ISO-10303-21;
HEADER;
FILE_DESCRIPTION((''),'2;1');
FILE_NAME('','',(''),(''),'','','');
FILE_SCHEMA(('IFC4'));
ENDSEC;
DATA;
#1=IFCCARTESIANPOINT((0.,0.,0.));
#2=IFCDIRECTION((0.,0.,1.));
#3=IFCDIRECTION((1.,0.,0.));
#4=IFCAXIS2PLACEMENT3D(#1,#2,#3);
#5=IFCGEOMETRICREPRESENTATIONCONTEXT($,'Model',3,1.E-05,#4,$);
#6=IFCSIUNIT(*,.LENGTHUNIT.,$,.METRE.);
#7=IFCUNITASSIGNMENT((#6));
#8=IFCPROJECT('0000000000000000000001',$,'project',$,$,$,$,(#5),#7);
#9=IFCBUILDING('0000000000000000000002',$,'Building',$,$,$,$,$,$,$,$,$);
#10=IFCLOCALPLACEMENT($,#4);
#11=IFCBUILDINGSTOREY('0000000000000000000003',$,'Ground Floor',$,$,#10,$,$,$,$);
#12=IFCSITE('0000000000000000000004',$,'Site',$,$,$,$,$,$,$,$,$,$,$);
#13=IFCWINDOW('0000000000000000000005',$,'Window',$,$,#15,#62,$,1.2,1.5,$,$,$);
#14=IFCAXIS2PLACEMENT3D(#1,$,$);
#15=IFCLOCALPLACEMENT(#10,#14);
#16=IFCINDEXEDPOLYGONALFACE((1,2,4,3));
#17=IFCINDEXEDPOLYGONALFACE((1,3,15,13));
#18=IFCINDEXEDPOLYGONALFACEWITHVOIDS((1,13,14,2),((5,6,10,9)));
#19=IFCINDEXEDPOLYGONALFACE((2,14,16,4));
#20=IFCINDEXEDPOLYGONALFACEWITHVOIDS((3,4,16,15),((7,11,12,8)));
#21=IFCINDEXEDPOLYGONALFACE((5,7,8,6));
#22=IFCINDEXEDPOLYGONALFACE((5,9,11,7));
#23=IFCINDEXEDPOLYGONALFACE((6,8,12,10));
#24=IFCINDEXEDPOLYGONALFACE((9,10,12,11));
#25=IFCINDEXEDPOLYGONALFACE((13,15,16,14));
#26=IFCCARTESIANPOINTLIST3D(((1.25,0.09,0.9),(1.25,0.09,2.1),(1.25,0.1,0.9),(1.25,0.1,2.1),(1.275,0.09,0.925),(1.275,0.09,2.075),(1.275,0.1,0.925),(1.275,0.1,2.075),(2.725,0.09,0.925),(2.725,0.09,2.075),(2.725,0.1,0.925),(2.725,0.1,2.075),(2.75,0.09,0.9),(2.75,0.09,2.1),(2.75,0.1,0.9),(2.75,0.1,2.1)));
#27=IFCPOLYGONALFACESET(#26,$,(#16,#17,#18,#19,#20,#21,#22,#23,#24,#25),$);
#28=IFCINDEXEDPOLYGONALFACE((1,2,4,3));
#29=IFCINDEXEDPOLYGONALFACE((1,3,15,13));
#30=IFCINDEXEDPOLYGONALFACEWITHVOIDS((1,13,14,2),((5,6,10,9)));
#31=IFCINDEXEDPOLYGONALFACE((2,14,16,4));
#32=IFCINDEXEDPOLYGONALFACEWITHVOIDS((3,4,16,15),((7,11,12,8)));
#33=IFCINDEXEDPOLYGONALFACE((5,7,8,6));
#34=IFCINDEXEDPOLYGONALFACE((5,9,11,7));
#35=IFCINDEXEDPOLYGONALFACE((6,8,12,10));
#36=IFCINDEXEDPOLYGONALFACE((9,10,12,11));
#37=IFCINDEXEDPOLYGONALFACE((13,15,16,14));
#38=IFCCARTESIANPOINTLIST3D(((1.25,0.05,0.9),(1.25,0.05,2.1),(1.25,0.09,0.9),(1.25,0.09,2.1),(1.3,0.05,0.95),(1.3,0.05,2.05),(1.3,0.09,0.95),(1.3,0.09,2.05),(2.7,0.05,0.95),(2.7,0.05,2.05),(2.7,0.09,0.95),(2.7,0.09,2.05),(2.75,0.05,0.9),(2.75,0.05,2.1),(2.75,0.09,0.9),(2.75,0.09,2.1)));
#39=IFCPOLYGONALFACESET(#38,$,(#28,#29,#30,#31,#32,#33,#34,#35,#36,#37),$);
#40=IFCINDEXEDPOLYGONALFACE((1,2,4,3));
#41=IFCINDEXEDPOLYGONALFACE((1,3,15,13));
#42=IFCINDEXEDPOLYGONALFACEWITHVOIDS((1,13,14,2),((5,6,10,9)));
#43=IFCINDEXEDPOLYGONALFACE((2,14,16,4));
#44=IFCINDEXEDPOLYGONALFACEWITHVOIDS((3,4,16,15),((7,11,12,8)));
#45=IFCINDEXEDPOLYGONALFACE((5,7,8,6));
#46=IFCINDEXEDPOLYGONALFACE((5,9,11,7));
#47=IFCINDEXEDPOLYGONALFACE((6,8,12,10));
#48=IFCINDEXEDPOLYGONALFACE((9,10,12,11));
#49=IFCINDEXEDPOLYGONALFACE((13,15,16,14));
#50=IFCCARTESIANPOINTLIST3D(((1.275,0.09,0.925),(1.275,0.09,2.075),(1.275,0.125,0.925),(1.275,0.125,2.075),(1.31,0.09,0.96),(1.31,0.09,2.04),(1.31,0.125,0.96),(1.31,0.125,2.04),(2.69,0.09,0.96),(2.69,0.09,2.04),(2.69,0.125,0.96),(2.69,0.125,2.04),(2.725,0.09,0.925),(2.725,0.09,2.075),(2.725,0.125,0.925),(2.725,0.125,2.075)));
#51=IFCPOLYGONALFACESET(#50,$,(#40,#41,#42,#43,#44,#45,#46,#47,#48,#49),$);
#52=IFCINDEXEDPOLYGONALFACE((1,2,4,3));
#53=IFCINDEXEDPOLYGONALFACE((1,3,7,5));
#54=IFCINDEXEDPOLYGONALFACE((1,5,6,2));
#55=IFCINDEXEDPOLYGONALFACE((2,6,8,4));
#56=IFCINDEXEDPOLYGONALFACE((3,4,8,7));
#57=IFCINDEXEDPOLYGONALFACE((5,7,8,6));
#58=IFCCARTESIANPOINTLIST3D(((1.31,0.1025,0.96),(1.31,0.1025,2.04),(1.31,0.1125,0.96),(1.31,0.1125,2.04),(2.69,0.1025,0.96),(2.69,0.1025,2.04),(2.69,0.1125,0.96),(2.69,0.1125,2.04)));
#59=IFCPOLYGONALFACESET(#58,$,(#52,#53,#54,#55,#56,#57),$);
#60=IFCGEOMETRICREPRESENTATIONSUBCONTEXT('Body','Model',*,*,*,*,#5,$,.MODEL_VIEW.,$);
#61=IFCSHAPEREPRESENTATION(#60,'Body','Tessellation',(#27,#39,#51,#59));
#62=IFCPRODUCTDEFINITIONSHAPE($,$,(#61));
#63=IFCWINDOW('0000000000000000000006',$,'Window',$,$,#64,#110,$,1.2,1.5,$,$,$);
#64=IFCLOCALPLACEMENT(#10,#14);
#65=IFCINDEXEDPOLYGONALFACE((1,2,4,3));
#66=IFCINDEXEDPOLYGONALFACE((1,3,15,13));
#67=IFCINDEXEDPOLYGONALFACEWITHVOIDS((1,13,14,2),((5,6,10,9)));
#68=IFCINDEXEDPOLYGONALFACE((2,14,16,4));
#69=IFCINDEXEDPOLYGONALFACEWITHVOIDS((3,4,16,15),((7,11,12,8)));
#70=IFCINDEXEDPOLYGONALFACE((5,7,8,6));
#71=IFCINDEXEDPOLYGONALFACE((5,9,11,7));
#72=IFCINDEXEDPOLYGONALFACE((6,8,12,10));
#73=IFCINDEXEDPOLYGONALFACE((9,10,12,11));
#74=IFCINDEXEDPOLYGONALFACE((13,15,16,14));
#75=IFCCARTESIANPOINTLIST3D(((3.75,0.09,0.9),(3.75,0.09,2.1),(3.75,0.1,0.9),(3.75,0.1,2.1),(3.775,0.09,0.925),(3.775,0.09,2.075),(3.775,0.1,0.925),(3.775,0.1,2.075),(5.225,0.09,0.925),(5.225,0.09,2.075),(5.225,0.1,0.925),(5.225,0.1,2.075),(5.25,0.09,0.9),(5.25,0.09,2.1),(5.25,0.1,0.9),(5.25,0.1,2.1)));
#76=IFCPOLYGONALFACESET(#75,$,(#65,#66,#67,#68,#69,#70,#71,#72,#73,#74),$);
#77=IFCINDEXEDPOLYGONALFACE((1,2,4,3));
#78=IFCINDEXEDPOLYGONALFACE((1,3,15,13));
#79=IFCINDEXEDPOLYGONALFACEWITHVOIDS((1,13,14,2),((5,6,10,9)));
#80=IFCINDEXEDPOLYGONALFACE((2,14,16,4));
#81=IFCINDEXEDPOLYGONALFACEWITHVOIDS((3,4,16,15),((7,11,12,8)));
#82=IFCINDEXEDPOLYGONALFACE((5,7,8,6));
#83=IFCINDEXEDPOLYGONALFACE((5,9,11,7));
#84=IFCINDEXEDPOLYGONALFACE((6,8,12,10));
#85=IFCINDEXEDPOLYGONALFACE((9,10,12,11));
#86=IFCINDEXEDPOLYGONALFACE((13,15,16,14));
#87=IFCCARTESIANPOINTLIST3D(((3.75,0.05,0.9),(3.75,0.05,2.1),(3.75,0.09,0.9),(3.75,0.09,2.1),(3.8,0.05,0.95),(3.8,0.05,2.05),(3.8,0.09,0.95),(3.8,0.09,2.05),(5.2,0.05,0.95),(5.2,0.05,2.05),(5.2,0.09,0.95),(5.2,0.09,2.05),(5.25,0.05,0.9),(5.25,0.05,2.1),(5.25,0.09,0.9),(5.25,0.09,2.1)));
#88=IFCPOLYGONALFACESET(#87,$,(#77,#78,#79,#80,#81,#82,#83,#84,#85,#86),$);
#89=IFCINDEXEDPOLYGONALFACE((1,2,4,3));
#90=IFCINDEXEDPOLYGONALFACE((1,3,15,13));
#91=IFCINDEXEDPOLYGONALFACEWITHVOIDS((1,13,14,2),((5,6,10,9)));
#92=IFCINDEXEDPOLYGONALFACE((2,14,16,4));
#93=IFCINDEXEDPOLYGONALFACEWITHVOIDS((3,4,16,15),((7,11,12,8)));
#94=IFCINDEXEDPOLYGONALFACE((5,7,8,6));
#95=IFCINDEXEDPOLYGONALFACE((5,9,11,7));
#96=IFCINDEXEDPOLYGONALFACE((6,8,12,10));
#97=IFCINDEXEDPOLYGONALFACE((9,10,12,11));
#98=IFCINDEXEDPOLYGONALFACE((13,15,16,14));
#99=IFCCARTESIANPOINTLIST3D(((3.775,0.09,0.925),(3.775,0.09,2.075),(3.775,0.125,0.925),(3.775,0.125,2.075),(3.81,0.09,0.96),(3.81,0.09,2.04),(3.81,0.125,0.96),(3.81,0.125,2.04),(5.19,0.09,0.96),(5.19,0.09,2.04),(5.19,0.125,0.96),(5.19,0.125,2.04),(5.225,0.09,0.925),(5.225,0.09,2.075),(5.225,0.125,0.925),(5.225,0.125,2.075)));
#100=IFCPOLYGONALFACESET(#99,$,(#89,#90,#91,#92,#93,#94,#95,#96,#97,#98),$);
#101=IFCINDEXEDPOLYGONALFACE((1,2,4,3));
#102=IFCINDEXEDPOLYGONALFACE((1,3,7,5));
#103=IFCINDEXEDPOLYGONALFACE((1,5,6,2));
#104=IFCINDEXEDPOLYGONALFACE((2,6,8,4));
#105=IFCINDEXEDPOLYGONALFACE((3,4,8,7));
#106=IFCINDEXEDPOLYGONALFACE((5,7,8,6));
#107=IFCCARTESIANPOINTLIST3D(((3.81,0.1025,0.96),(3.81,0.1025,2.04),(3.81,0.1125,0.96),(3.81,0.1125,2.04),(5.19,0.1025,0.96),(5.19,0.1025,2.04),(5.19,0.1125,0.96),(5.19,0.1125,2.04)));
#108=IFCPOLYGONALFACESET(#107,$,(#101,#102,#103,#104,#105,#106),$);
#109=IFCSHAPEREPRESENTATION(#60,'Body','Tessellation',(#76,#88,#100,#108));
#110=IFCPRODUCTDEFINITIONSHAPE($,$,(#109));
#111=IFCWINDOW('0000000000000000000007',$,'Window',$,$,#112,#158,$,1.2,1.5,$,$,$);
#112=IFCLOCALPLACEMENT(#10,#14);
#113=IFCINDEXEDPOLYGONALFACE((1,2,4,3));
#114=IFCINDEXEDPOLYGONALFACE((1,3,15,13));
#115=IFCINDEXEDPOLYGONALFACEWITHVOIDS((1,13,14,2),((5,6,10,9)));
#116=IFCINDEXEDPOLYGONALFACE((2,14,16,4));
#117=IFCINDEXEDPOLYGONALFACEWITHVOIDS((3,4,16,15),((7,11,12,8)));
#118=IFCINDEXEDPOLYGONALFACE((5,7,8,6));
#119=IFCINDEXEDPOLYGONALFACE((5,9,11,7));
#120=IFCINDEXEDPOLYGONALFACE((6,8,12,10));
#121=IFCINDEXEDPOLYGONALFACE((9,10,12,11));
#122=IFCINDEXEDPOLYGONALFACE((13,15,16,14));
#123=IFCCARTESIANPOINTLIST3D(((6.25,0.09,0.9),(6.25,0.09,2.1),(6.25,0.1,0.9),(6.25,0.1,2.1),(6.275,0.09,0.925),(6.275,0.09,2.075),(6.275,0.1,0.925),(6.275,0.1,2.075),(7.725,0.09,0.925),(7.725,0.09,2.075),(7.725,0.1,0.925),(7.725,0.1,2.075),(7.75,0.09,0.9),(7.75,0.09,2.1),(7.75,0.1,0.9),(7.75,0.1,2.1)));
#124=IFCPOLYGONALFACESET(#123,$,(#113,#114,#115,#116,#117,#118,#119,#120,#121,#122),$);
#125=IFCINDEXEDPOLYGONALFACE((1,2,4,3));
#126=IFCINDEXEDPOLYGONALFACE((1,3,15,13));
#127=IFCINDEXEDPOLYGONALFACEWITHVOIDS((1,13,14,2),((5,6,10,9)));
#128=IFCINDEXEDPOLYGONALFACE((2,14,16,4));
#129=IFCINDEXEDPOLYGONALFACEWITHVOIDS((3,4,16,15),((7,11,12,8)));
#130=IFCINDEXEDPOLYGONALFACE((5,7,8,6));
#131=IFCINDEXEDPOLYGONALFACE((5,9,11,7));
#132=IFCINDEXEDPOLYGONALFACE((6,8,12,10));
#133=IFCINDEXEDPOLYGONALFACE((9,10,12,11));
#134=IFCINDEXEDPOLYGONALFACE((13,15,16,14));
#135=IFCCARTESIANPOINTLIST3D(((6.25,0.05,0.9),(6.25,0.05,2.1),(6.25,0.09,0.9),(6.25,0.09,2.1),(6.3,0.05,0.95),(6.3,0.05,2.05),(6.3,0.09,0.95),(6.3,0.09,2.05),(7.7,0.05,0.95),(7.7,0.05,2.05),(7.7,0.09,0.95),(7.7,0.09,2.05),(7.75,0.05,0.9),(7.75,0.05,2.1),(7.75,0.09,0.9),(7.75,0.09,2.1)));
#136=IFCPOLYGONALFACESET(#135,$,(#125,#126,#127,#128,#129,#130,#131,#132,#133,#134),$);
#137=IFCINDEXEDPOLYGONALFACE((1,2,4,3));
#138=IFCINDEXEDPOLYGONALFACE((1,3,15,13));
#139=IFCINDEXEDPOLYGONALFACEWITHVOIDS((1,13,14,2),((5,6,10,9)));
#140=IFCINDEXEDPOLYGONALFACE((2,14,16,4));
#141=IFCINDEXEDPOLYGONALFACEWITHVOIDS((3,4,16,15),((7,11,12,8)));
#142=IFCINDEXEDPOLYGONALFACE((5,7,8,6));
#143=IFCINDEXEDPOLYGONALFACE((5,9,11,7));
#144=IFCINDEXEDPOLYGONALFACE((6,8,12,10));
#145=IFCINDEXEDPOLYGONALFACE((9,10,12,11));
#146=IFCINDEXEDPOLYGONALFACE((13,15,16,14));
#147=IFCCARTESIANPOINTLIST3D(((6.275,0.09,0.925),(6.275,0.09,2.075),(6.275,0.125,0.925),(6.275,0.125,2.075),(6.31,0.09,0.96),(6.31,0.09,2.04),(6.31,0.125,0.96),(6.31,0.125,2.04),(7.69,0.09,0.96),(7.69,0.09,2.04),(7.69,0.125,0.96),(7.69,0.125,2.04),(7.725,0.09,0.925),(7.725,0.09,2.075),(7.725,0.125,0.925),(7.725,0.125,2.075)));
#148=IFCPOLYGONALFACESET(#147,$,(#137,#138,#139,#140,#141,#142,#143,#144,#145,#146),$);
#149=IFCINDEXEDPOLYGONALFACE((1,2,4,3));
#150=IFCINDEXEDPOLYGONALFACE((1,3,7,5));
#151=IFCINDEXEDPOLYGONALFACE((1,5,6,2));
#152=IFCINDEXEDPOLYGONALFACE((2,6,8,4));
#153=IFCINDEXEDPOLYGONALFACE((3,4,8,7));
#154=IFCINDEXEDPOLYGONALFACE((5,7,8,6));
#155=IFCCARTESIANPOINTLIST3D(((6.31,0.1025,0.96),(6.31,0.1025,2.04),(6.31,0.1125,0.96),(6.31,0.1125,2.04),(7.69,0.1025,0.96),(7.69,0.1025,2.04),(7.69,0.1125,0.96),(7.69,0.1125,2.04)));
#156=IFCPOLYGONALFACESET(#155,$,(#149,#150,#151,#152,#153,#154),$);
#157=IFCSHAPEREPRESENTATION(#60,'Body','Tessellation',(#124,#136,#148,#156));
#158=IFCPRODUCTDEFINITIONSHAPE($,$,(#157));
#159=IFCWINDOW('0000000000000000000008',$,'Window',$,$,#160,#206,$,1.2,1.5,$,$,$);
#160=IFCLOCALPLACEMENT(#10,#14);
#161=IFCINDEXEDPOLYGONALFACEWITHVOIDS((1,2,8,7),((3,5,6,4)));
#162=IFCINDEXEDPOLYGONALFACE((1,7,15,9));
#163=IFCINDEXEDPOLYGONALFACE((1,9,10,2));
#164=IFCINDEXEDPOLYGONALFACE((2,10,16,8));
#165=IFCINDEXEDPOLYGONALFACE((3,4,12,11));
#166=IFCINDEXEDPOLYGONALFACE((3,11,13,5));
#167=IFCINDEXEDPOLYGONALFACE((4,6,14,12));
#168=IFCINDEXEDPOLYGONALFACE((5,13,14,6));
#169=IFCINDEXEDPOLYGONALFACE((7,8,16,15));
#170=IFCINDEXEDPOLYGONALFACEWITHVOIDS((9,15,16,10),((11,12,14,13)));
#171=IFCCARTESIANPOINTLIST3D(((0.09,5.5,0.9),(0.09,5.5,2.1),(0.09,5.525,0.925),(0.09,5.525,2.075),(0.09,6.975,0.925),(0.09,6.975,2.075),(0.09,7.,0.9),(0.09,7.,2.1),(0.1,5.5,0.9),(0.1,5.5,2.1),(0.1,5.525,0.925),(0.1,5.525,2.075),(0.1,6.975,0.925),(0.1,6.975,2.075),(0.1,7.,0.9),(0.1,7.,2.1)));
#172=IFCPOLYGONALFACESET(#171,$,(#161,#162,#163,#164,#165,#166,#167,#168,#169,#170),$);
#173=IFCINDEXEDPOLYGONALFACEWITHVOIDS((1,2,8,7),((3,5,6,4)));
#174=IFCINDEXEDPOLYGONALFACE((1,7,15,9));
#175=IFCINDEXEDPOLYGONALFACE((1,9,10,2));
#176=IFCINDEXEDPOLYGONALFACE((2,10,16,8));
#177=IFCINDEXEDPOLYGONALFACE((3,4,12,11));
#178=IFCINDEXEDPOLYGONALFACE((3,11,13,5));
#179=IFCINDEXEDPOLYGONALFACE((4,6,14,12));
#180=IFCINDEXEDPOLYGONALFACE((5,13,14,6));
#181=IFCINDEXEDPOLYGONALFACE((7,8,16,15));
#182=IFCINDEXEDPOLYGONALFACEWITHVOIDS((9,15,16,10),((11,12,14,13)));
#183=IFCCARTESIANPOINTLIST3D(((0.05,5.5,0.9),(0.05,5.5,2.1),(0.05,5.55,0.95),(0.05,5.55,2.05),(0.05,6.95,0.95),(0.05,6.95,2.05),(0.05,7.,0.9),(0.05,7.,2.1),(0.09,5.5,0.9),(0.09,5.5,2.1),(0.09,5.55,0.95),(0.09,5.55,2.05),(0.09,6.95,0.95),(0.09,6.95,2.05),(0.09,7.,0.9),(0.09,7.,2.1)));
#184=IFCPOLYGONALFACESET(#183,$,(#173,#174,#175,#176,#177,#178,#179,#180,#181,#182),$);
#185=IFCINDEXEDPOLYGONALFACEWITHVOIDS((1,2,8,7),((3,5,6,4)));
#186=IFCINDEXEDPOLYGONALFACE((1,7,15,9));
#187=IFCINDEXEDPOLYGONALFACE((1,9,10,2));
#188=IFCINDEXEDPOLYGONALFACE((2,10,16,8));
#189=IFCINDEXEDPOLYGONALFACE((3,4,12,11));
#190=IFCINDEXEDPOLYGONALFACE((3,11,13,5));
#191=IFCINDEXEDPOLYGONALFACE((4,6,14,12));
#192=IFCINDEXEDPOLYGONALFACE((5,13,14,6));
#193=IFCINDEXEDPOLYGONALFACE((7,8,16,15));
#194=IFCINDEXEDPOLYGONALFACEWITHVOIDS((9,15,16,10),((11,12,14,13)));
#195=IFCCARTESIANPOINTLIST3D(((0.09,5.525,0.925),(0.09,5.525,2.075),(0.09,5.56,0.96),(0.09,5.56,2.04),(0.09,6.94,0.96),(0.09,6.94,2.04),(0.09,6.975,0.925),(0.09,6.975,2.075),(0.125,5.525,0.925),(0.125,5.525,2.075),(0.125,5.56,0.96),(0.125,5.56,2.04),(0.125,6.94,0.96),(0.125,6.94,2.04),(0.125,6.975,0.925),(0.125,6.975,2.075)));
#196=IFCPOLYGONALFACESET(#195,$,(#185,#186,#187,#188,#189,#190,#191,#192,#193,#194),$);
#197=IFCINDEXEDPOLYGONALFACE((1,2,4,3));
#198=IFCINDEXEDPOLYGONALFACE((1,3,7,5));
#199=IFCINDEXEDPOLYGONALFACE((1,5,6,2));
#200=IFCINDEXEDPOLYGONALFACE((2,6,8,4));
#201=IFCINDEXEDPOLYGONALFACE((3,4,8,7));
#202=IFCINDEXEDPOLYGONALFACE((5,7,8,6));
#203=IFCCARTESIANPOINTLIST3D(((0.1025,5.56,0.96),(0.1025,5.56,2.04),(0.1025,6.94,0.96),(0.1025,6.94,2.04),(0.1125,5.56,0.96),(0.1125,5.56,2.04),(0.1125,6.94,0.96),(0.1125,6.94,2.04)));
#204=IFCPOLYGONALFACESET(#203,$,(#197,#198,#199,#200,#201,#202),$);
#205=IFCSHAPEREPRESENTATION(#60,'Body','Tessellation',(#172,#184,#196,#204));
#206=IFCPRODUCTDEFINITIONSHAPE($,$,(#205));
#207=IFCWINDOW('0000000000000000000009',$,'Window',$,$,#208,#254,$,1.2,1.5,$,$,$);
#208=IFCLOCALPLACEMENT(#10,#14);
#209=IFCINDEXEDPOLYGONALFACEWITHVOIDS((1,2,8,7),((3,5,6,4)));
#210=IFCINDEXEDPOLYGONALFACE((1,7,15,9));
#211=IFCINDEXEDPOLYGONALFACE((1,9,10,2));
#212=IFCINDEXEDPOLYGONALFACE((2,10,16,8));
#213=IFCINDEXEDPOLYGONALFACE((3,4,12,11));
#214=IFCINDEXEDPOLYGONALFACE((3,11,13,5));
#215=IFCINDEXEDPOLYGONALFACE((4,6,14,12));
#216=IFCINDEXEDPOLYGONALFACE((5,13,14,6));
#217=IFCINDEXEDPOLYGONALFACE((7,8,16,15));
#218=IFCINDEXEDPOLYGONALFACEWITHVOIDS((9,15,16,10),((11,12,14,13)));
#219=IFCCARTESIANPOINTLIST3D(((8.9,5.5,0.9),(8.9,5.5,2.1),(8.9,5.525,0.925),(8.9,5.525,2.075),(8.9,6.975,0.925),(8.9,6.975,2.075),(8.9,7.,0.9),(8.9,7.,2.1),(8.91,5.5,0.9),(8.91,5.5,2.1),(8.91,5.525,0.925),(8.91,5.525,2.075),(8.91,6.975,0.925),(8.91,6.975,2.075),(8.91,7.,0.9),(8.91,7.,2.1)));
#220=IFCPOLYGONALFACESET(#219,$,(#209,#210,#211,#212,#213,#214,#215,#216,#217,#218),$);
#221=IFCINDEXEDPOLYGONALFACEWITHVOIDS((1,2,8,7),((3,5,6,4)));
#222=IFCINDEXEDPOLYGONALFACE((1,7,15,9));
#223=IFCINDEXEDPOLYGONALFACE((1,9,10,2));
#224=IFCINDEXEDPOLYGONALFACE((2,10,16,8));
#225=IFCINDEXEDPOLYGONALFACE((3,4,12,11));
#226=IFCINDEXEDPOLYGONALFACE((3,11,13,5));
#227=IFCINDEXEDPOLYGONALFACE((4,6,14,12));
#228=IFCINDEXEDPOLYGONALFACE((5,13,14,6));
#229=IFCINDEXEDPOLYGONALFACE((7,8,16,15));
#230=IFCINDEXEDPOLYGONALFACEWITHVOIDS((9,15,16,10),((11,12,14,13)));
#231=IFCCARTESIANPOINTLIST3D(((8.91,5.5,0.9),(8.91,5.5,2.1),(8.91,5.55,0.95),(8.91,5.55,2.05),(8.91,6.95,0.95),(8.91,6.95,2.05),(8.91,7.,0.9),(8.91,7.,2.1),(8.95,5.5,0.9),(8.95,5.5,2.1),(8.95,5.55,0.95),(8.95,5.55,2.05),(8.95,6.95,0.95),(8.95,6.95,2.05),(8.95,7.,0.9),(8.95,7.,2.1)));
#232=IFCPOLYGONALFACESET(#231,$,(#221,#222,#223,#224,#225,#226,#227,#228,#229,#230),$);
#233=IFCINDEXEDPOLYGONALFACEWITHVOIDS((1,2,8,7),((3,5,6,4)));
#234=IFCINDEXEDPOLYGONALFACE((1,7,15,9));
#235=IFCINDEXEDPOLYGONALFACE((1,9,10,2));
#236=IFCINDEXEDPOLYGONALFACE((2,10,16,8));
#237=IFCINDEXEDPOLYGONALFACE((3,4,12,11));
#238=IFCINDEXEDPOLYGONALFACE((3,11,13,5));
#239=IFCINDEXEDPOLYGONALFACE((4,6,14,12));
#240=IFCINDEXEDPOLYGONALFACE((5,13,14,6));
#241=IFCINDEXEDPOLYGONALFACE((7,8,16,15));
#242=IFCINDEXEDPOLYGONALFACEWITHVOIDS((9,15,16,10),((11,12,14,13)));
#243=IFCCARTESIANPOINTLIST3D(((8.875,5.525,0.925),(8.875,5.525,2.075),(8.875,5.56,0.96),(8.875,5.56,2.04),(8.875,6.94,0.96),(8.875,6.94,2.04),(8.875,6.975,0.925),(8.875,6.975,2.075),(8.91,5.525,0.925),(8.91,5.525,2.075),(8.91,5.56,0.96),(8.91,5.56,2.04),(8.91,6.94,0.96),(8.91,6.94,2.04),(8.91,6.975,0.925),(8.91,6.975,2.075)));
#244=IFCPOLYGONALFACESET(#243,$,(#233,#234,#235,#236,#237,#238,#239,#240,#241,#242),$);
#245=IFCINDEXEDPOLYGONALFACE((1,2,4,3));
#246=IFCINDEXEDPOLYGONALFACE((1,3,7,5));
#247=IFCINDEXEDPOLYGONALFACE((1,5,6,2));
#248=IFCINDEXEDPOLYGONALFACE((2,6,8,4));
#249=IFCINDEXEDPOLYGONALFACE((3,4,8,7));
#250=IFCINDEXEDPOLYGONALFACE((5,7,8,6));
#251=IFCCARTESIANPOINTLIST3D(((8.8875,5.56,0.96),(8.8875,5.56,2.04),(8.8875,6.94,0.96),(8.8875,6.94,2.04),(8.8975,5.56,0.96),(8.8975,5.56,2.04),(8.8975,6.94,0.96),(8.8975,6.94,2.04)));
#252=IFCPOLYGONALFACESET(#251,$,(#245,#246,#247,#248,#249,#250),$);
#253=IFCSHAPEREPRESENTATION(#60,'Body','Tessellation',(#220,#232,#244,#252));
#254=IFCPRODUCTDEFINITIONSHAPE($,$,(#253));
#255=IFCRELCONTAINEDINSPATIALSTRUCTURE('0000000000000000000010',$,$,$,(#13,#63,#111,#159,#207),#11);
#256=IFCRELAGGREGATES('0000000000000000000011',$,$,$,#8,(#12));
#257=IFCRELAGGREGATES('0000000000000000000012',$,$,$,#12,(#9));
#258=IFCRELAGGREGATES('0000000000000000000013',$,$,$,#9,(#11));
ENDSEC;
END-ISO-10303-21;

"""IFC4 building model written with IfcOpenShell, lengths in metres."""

from ifc_helpers import new_model, si_unit, frame, origin_with_axes, place, context, subcontext, project, spatial, line, indexed_curve, outline, extrude, element, save


model = new_model("IFC4")

# Units and contexts
model_context = context("Model", 3, precision=1e-05, world=origin_with_axes())
body_context = subcontext(model_context, "Body", "Model", "MODEL_VIEW")
ifc_project = project(units=[si_unit("LENGTHUNIT", "METRE")], contexts=[model_context])

# Site, building, storey
site = spatial("IfcSite", under=ifc_project, Name="Site")
building = spatial("IfcBuilding", under=site, Name="Building")
storey_placement = place(None, origin_with_axes())
storey = spatial("IfcBuildingStorey", under=building, at=storey_placement, Name="Ground Floor")

# Windows
for number, where, z_axis, x_axis, name in (
    (1, (1.25, 0.0, 0.9), (0.0, 0.0, 1.0), (1.0, 0.0, 0.0), "Window"),
    (2, (3.75, 0.0, 0.9), (0.0, 0.0, 1.0), (1.0, 0.0, 0.0), "Window"),
    (3, (6.25, 0.0, 0.9), (0.0, 0.0, 1.0), (1.0, 0.0, 0.0), "Window"),
    (4, (0.0, 7.0, 0.9), (0.0, 0.0, 1.0), (0.0, -1.0, 0.0), "Window"),
    (5, (9.0, 5.5, 0.9), (0.0, 0.0, 1.0), (0.0, 1.0, 0.0), "Window"),
):
    element("IfcWindow", number, at=place(storey_placement, frame(where, z_axis=z_axis, x_axis=x_axis)), inside=storey, Name=name, OverallHeight=1.2, OverallWidth=1.5, context=body_context, shape_type="SweptSolid", body=[
        extrude(outline(indexed_curve([(0.0, 0.0), (1.5, 0.0), (1.5, 1.2), (0.0, 1.2)], segments=[line(1, 2, 3, 4, 1)]), holes=[indexed_curve([(0.025, 0.025), (1.475, 0.025), (1.475, 1.175), (0.025, 1.175)], segments=[line(1, 2, 3, 4, 1)])]), frame((0.0, 0.09, 0.0), z_axis=(0.0, -1.0, 0.0), x_axis=(1.0, 0.0, 0.0)), (0.0, 0.0, -1.0), 0.01),
        extrude(outline(indexed_curve([(0.0, 0.0), (1.5, 0.0), (1.5, 1.2), (0.0, 1.2)], segments=[line(1, 2, 3, 4, 1)]), holes=[indexed_curve([(0.05, 0.05), (1.45, 0.05), (1.45, 1.15), (0.05, 1.15)], segments=[line(1, 2, 3, 4, 1)])]), frame((0.0, 0.05, 0.0), z_axis=(0.0, -1.0, 0.0), x_axis=(1.0, 0.0, 0.0)), (0.0, 0.0, -1.0), 0.04),
        extrude(outline(indexed_curve([(0.0, 0.0), (1.45, 0.0), (1.45, 1.15), (0.0, 1.15)], segments=[line(1, 2, 3, 4, 1)]), holes=[indexed_curve([(0.035, 0.035), (1.415, 0.035), (1.415, 1.115), (0.035, 1.115)], segments=[line(1, 2, 3, 4, 1)])]), frame((0.025, 0.09, 0.025), z_axis=(0.0, -1.0, 0.0), x_axis=(1.0, 0.0, 0.0)), (0.0, 0.0, -1.0), 0.035),
        extrude(outline(indexed_curve([(0.035, 0.035), (1.415, 0.035), (1.415, 1.115), (0.035, 1.115)], segments=[line(1, 2, 3, 4, 1)])), frame((0.025, 0.1025, 0.025), z_axis=(0.0, -1.0, 0.0), x_axis=(1.0, 0.0, 0.0)), (0.0, 0.0, -1.0), 0.01),
    ])

save(model, "model.ifc")
